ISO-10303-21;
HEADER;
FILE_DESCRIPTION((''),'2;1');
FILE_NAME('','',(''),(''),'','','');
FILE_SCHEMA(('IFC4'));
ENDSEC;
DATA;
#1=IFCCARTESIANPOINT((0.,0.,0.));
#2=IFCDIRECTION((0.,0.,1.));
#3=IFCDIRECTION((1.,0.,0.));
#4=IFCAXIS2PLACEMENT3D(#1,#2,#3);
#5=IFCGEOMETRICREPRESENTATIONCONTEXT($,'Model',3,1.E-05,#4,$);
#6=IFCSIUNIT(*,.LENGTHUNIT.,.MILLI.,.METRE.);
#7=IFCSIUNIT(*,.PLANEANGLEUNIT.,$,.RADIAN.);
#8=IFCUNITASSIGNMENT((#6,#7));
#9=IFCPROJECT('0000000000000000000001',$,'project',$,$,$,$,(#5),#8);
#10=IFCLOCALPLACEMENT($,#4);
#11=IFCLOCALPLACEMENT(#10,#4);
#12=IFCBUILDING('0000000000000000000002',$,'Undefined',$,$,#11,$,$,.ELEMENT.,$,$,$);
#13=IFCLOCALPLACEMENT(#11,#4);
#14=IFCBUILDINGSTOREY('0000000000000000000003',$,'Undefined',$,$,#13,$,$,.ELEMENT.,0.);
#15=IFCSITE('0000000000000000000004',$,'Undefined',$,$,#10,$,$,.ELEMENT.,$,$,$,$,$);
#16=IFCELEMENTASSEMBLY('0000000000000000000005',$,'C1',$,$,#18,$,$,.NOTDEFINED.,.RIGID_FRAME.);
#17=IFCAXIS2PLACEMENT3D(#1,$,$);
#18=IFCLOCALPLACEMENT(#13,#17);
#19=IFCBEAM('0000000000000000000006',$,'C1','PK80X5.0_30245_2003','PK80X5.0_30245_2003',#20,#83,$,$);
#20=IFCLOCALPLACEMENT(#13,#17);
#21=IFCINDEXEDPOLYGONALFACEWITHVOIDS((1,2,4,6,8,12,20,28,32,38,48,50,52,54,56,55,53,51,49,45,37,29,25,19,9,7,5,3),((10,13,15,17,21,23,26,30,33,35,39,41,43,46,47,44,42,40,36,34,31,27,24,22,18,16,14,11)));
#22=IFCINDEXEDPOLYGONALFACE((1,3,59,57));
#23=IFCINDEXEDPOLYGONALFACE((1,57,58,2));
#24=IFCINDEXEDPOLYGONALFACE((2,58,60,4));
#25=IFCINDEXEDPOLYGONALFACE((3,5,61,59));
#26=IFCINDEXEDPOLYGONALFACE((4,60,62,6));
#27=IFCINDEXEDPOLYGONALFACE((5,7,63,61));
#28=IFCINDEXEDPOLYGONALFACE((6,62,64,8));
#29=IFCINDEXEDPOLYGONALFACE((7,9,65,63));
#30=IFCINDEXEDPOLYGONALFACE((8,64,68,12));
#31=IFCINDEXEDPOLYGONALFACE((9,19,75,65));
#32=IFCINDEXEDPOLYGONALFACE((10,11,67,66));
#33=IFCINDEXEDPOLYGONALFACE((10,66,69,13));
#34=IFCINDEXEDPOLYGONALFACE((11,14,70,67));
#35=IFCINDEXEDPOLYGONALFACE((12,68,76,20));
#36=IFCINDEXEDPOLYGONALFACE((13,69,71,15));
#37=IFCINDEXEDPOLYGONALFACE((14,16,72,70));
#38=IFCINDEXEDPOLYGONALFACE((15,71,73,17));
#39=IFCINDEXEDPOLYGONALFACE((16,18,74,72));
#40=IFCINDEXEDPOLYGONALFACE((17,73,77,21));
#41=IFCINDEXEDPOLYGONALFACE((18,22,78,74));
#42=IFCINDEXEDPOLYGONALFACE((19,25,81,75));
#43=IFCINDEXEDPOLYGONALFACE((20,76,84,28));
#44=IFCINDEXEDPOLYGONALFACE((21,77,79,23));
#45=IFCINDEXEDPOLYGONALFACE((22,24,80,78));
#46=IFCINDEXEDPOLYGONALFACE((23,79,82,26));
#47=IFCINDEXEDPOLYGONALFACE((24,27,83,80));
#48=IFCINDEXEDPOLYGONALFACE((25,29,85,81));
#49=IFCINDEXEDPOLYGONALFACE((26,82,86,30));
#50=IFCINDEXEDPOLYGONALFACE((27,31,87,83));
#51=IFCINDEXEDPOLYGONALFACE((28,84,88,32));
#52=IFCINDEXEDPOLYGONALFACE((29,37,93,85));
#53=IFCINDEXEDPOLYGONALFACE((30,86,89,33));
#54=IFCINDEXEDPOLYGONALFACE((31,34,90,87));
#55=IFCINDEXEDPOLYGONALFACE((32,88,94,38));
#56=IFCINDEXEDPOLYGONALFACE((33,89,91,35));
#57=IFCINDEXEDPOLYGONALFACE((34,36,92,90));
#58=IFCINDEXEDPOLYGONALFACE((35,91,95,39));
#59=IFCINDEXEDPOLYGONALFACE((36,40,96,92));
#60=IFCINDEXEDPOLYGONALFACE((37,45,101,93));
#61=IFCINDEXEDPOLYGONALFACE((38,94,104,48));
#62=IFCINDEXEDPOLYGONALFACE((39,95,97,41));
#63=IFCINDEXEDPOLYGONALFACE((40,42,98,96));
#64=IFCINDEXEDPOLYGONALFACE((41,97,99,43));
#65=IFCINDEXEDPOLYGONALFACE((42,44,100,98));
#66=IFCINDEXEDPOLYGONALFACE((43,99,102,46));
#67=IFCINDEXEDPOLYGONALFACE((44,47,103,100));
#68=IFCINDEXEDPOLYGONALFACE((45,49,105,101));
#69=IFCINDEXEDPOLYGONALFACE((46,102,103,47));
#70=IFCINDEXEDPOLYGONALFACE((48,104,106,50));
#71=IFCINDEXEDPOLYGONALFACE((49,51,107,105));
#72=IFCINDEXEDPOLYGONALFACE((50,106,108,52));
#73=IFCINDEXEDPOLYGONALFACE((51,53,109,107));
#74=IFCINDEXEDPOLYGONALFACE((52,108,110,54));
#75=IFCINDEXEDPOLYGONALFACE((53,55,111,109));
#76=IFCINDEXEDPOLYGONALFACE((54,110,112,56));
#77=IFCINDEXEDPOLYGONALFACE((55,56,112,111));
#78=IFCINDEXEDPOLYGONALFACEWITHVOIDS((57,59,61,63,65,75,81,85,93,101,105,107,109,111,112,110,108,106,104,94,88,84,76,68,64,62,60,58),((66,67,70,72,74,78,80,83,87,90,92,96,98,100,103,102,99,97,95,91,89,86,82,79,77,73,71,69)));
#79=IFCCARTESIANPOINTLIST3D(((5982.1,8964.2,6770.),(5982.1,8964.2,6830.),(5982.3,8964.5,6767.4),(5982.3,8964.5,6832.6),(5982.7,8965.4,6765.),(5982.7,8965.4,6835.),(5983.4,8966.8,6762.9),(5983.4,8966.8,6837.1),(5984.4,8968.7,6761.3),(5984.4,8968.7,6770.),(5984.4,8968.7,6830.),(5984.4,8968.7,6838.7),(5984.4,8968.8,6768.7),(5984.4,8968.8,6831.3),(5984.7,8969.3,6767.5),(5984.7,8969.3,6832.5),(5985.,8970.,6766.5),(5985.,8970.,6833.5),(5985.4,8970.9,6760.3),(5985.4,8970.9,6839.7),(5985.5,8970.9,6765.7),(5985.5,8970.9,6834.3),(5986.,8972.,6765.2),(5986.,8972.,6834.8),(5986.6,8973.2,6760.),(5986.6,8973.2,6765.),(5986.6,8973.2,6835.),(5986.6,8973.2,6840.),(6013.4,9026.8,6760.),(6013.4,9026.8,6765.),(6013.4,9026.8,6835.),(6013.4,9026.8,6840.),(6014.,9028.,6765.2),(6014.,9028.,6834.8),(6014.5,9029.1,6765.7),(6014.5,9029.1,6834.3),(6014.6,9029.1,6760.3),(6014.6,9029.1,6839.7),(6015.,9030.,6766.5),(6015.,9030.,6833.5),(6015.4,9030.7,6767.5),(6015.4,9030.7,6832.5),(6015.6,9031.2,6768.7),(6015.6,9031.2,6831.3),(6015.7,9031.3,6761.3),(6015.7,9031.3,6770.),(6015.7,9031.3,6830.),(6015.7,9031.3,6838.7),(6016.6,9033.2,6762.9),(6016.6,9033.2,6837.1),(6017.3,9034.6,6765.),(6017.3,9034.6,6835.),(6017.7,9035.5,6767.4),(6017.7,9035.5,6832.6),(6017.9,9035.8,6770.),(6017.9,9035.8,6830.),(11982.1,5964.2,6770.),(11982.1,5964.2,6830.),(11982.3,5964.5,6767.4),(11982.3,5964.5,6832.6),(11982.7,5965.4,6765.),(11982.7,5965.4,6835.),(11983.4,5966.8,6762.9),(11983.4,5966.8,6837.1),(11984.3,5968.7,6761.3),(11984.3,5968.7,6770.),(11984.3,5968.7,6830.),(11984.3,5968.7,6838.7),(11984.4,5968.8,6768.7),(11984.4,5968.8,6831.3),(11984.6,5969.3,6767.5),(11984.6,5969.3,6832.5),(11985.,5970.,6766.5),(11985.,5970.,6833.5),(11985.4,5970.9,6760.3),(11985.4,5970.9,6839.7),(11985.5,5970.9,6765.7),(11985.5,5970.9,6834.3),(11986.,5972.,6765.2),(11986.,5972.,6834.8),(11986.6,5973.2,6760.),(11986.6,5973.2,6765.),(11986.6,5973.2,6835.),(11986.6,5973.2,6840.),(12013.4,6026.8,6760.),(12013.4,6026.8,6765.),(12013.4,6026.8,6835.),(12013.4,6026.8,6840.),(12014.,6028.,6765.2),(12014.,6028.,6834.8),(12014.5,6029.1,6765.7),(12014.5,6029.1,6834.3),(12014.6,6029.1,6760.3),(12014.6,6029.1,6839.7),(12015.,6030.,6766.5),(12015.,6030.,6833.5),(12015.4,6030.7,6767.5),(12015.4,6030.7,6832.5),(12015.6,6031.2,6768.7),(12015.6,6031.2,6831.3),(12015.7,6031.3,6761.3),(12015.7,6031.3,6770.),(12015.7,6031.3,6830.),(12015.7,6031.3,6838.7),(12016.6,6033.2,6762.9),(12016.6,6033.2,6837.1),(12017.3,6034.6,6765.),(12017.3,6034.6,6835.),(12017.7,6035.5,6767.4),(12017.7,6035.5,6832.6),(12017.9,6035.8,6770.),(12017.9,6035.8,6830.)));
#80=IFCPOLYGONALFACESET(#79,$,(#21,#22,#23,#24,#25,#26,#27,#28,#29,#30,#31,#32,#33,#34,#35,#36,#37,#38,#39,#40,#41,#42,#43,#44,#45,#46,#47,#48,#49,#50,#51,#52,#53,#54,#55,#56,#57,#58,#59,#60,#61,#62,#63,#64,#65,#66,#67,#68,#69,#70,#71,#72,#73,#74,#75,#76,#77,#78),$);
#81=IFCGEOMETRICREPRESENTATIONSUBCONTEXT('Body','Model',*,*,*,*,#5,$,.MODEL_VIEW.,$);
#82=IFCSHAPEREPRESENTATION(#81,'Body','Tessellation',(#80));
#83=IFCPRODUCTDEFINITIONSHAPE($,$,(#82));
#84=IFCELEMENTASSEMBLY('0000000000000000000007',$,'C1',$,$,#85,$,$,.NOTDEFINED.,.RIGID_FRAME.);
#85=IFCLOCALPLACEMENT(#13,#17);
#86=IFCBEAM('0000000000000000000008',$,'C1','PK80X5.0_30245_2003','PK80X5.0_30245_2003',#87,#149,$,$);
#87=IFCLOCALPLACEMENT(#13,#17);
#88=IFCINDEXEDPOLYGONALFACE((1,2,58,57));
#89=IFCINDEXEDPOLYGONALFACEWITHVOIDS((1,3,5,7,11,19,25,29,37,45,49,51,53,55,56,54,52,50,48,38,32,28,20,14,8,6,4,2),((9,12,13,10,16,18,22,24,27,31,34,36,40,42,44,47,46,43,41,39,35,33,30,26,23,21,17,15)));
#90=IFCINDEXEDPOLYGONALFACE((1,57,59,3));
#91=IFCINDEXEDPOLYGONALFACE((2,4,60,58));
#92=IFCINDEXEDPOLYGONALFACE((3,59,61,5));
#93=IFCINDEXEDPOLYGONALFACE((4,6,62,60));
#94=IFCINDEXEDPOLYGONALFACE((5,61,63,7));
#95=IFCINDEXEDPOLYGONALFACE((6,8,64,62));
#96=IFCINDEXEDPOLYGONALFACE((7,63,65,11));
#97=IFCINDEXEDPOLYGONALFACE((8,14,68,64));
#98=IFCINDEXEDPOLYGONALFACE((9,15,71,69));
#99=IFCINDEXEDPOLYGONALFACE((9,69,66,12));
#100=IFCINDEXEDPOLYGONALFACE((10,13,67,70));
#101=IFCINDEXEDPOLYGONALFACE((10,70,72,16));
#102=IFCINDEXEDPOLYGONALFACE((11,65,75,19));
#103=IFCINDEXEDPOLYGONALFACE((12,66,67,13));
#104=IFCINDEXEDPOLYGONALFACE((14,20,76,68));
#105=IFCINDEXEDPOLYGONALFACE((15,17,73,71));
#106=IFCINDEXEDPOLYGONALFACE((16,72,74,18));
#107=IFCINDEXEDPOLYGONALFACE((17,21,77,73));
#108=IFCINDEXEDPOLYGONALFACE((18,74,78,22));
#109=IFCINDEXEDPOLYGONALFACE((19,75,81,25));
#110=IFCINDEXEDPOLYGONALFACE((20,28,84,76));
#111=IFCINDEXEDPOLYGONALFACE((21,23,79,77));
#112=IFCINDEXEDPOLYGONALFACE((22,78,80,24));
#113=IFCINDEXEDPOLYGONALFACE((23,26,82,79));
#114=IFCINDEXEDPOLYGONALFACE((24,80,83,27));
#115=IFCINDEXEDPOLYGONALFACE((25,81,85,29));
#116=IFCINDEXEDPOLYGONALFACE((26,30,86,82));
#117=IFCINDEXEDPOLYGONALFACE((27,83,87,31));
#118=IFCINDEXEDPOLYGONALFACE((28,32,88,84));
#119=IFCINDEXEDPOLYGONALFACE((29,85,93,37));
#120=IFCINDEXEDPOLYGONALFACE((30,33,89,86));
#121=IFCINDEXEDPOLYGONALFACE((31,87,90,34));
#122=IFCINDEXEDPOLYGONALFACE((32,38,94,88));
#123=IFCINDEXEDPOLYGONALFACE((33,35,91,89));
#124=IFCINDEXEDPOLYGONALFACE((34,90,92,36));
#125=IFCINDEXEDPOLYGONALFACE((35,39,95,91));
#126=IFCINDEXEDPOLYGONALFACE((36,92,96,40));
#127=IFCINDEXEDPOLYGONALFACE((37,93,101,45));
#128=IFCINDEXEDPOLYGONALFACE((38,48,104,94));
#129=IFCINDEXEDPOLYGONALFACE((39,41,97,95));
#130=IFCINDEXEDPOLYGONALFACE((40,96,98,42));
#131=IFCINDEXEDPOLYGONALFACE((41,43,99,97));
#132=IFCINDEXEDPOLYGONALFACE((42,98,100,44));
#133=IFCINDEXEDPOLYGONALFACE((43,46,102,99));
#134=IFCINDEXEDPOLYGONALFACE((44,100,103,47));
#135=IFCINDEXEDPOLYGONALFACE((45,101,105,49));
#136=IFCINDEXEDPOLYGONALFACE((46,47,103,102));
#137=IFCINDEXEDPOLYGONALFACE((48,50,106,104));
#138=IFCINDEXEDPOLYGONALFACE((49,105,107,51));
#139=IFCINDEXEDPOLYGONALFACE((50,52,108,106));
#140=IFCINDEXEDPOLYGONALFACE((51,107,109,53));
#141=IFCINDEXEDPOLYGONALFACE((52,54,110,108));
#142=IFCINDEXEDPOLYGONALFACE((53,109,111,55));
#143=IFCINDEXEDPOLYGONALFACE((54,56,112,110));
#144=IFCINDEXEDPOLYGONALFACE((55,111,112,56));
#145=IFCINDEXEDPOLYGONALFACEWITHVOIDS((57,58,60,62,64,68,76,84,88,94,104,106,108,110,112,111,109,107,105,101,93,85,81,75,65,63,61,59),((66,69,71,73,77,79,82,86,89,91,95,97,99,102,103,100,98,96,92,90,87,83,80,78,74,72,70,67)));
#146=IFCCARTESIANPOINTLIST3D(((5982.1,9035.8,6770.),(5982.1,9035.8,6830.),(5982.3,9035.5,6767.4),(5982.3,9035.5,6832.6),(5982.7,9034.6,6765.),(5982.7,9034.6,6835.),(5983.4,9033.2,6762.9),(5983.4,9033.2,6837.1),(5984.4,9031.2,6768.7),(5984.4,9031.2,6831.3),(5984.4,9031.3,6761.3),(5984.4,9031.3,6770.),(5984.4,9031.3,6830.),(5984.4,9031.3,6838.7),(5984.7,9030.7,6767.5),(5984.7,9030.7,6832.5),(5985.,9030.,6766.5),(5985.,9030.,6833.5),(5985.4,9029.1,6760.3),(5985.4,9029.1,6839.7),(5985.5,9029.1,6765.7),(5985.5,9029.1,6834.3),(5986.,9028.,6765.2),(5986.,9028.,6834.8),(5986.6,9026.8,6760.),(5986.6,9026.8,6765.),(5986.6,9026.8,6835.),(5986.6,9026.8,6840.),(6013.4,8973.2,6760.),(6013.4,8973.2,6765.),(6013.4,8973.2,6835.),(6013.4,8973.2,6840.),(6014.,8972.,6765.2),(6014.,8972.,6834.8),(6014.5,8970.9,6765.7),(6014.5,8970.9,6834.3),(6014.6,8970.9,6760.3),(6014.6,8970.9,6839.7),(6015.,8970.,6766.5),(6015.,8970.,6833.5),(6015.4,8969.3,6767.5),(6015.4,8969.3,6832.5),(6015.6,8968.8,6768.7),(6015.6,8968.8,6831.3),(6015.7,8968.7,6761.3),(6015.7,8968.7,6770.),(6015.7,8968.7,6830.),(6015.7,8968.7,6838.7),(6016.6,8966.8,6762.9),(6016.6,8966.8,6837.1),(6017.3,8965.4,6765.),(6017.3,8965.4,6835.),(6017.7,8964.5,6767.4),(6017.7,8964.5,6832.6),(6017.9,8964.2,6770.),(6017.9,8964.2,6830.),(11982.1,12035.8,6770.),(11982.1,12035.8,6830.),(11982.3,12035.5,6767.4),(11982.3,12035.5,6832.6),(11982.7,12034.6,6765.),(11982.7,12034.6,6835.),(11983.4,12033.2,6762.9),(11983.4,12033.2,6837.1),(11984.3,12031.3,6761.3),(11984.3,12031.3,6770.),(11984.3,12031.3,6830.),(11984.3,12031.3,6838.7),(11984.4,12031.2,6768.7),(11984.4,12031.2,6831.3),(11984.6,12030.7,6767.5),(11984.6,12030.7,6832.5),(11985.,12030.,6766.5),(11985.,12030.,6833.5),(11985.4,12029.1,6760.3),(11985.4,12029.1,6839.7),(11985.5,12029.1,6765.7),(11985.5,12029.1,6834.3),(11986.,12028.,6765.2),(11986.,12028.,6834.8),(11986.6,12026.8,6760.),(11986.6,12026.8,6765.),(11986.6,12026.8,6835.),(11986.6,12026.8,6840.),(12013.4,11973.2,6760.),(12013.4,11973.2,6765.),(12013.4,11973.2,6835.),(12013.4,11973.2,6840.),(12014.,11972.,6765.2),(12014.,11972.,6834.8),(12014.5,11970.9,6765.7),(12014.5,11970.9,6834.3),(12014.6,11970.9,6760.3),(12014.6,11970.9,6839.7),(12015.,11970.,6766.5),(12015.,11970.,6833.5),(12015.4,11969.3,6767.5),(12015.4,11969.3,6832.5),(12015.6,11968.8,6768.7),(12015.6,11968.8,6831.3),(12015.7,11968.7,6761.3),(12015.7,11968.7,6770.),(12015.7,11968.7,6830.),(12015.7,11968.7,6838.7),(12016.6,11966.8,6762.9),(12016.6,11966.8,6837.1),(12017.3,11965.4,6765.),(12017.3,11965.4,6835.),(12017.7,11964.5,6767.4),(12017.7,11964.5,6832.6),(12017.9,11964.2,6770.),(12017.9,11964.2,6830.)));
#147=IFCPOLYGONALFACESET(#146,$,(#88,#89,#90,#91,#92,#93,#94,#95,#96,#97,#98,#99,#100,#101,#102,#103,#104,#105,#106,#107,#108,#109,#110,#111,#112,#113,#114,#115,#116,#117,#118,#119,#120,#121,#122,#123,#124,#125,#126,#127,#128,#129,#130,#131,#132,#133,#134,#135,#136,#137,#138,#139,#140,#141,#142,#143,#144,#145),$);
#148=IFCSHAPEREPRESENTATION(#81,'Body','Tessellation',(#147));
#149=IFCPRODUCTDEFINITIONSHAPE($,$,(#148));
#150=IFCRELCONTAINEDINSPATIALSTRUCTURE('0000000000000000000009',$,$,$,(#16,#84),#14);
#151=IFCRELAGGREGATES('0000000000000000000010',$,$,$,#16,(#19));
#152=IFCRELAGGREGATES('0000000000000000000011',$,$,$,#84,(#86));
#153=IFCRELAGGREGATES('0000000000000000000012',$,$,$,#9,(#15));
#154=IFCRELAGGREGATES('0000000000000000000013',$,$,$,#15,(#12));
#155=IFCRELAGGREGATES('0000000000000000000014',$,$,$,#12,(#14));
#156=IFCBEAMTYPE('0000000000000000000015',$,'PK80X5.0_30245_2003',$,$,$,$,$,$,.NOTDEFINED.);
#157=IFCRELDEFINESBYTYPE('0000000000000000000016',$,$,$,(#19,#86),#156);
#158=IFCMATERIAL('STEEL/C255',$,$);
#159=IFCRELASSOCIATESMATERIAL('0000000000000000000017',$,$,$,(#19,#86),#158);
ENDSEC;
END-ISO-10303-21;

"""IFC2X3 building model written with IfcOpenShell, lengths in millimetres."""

from ifc_helpers import new_model, si_unit, frame, origin_with_axes, origin_2d_with_axis, place, context, subcontext, project, spatial, hollow_rectangle, extrude, material, type_object, element, aggregate, save


model = new_model("IFC2X3")

# Units and contexts
model_context = context("Model", 3, precision=1e-05, world=origin_with_axes())
body_context = subcontext(model_context, "Body", "Model", "MODEL_VIEW")
ifc_project = project(units=[si_unit("LENGTHUNIT", "METRE", prefix="MILLI"), si_unit("PLANEANGLEUNIT", "RADIAN")], contexts=[model_context])

# Site, building, storey
site_placement = place(None, origin_with_axes())
site = spatial("IfcSite", under=ifc_project, at=site_placement, Name="Undefined", CompositionType="ELEMENT")
building_placement = place(site_placement, origin_with_axes())
building = spatial("IfcBuilding", under=site, at=building_placement, Name="Undefined", CompositionType="ELEMENT")
storey_placement = place(building_placement, origin_with_axes())
storey = spatial("IfcBuildingStorey", under=building, at=storey_placement, Name="Undefined", CompositionType="ELEMENT", Elevation=0.0)

# Element assemblies, beams
assembly_1_placement = place(storey_placement, origin_with_axes())
assembly_1 = element("IfcElementAssembly", 1, at=assembly_1_placement, inside=storey, Name="C1", AssemblyPlace="NOTDEFINED", PredefinedType="RIGID_FRAME")
ifc_material_1 = material(Name="STEEL/C255")
beam_type_1 = type_object("IfcBeamType", Name="PK80X5.0_30245_2003", PredefinedType="NOTDEFINED")
beam_1_placement = place(assembly_1_placement, frame((6000.0, 9000.0, 6800.0), z_axis=(0.0, 0.0, -1.0), x_axis=(0.894427, -0.447214, 0.0)))
beam_1 = element("IfcBeam", 2, at=beam_1_placement, type_object=beam_type_1, material=ifc_material_1, Name="C1", Description="PK80X5.0_30245_2003", ObjectType="PK80X5.0_30245_2003", context=body_context, shape_type="SweptSolid", body=[
    extrude(hollow_rectangle(XDim=80.0, YDim=80.0, WallThickness=5.0, InnerFilletRadius=5.0, OuterFilletRadius=10.0, at=origin_2d_with_axis()), frame((6708.2, 0.0, 0.0), z_axis=(-1.0, 0.0, 0.0), x_axis=(0.0, -1.0, 0.0)), (0.0, 0.0, 1.0), 6708.2),
])
aggregate(assembly_1, [beam_1])
assembly_2_placement = place(storey_placement, origin_with_axes())
assembly_2 = element("IfcElementAssembly", 3, at=assembly_2_placement, inside=storey, Name="C1", AssemblyPlace="NOTDEFINED", PredefinedType="RIGID_FRAME")
beam_2_placement = place(assembly_2_placement, frame((6000.0, 9000.0, 6800.0), z_axis=(0.0, 0.0, -1.0), x_axis=(0.894427, 0.447214, 0.0)))
beam_2 = element("IfcBeam", 4, at=beam_2_placement, type_object=beam_type_1, material=ifc_material_1, Name="C1", Description="PK80X5.0_30245_2003", ObjectType="PK80X5.0_30245_2003", context=body_context, shape_type="SweptSolid", body=[
    extrude(hollow_rectangle(XDim=80.0, YDim=80.0, WallThickness=5.0, InnerFilletRadius=5.0, OuterFilletRadius=10.0, at=origin_2d_with_axis()), frame((6708.2, 0.0, 0.0), z_axis=(-1.0, 0.0, 0.0), x_axis=(0.0, -1.0, 0.0)), (0.0, 0.0, 1.0), 6708.2),
])
aggregate(assembly_2, [beam_2])

save(model, "model.ifc")
